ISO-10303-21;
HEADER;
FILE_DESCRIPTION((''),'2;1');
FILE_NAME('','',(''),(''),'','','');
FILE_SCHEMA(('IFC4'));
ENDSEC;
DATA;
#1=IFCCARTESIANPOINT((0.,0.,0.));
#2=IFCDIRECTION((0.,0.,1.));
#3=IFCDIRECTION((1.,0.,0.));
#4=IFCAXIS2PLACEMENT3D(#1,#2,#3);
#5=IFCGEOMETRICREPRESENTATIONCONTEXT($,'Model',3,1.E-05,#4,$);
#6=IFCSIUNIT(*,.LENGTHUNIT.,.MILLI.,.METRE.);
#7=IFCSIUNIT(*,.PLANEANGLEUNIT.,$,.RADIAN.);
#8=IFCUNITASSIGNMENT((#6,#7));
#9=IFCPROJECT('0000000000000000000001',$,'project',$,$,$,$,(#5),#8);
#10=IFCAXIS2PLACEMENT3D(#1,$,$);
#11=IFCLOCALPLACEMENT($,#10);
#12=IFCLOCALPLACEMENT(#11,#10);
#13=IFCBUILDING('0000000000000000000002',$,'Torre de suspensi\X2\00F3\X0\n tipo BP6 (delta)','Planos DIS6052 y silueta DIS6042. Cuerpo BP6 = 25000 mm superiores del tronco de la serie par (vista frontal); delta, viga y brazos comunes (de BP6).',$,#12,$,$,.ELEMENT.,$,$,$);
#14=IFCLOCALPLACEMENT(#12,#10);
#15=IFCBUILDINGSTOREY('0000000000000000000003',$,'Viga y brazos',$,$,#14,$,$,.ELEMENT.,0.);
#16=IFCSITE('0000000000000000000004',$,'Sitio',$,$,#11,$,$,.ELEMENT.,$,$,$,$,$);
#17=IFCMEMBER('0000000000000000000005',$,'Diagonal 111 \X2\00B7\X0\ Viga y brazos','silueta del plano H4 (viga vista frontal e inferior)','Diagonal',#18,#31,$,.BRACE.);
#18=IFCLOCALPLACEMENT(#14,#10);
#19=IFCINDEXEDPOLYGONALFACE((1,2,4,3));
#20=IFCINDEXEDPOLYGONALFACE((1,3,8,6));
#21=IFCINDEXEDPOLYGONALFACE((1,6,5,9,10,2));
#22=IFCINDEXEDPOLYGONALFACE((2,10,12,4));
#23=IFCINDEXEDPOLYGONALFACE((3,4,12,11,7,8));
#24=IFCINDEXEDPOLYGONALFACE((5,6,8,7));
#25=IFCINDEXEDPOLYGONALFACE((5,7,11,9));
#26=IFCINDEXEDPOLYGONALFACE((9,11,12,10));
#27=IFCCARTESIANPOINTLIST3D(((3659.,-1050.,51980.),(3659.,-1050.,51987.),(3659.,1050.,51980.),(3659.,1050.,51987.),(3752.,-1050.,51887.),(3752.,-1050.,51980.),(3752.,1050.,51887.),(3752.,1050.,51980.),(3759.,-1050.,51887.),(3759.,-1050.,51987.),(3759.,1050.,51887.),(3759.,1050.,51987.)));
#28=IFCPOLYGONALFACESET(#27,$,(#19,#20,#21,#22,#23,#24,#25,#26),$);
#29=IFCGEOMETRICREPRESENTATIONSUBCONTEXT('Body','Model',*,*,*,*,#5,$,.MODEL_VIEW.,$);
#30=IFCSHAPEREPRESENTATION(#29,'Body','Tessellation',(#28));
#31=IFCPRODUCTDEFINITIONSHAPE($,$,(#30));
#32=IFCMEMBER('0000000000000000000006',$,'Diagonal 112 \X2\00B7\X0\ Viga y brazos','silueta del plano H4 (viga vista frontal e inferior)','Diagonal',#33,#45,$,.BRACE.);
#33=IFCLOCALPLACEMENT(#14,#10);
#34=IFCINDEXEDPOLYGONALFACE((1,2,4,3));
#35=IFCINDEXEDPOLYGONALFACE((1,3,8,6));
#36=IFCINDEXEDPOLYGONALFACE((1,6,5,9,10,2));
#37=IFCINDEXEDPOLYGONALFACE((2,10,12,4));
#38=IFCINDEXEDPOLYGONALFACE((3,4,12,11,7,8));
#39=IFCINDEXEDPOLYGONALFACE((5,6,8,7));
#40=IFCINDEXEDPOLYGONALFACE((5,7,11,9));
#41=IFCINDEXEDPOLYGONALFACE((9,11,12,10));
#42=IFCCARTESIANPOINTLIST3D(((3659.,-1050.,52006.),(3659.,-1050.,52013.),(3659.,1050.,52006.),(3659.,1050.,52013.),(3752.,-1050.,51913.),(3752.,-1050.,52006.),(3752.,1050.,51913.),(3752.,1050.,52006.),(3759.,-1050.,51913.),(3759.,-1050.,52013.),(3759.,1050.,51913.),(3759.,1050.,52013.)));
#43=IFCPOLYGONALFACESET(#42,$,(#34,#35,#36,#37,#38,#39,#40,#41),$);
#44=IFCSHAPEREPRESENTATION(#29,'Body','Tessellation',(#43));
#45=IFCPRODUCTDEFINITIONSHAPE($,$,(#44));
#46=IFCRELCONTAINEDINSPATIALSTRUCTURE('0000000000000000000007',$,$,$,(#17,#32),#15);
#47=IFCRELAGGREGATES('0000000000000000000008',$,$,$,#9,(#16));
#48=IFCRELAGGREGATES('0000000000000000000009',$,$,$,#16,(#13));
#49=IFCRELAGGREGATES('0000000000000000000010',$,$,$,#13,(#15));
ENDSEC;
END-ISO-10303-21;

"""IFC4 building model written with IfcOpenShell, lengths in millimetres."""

from ifc_helpers import new_model, si_unit, frame, frame_2d, origin, origin_with_axes, place, context, subcontext, project, spatial, l_section, extrude, element, save


model = new_model("IFC4")

# Units and contexts
model_context = context("Model", 3, precision=1e-05, world=origin_with_axes())
body_context = subcontext(model_context, "Body", "Model", "MODEL_VIEW")
ifc_project = project(units=[si_unit("LENGTHUNIT", "METRE", prefix="MILLI"), si_unit("PLANEANGLEUNIT", "RADIAN")], contexts=[model_context])

# Site, building, storey
site_placement = place(None, origin())
site = spatial("IfcSite", under=ifc_project, at=site_placement, Name="Sitio", CompositionType="ELEMENT")
building_placement = place(site_placement, origin())
building = spatial("IfcBuilding", under=site, at=building_placement, Name="Torre de suspensión tipo BP6 (delta)", Description="Planos DIS6052 y silueta DIS6042. Cuerpo BP6 = 25000 mm superiores del tronco de la serie par (vista frontal); delta, viga y brazos comunes (de BP6).", CompositionType="ELEMENT")
storey_placement = place(building_placement, origin())
storey = spatial("IfcBuildingStorey", under=building, at=storey_placement, Name="Viga y brazos", CompositionType="ELEMENT", Elevation=0.0)

# Members
for number, where, z_axis, x_axis, name in (
    (1, (3759.0, 1050.0, 51987.0), (0.0, -1.0, 0.0), (-1.0, 0.0, 0.0), "Diagonal 111 · Viga y brazos"),
    (2, (3759.0, 1050.0, 52013.0), (0.0, -1.0, 0.0), (-1.0, 0.0, 0.0), "Diagonal 112 · Viga y brazos"),
):
    element("IfcMember", number, at=place(storey_placement, frame(where, z_axis=z_axis, x_axis=x_axis)), inside=storey, Name=name, Description="silueta del plano H4 (viga vista frontal e inferior)", ObjectType="Diagonal", PredefinedType="BRACE", context=body_context, shape_type="SweptSolid", body=[
        extrude(l_section(Depth=100.0, Width=100.0, Thickness=7.0, at=frame_2d((50.0, 50.0))), None, (0.0, 0.0, 1.0), 2100.0),
    ])

save(model, "model.ifc")
